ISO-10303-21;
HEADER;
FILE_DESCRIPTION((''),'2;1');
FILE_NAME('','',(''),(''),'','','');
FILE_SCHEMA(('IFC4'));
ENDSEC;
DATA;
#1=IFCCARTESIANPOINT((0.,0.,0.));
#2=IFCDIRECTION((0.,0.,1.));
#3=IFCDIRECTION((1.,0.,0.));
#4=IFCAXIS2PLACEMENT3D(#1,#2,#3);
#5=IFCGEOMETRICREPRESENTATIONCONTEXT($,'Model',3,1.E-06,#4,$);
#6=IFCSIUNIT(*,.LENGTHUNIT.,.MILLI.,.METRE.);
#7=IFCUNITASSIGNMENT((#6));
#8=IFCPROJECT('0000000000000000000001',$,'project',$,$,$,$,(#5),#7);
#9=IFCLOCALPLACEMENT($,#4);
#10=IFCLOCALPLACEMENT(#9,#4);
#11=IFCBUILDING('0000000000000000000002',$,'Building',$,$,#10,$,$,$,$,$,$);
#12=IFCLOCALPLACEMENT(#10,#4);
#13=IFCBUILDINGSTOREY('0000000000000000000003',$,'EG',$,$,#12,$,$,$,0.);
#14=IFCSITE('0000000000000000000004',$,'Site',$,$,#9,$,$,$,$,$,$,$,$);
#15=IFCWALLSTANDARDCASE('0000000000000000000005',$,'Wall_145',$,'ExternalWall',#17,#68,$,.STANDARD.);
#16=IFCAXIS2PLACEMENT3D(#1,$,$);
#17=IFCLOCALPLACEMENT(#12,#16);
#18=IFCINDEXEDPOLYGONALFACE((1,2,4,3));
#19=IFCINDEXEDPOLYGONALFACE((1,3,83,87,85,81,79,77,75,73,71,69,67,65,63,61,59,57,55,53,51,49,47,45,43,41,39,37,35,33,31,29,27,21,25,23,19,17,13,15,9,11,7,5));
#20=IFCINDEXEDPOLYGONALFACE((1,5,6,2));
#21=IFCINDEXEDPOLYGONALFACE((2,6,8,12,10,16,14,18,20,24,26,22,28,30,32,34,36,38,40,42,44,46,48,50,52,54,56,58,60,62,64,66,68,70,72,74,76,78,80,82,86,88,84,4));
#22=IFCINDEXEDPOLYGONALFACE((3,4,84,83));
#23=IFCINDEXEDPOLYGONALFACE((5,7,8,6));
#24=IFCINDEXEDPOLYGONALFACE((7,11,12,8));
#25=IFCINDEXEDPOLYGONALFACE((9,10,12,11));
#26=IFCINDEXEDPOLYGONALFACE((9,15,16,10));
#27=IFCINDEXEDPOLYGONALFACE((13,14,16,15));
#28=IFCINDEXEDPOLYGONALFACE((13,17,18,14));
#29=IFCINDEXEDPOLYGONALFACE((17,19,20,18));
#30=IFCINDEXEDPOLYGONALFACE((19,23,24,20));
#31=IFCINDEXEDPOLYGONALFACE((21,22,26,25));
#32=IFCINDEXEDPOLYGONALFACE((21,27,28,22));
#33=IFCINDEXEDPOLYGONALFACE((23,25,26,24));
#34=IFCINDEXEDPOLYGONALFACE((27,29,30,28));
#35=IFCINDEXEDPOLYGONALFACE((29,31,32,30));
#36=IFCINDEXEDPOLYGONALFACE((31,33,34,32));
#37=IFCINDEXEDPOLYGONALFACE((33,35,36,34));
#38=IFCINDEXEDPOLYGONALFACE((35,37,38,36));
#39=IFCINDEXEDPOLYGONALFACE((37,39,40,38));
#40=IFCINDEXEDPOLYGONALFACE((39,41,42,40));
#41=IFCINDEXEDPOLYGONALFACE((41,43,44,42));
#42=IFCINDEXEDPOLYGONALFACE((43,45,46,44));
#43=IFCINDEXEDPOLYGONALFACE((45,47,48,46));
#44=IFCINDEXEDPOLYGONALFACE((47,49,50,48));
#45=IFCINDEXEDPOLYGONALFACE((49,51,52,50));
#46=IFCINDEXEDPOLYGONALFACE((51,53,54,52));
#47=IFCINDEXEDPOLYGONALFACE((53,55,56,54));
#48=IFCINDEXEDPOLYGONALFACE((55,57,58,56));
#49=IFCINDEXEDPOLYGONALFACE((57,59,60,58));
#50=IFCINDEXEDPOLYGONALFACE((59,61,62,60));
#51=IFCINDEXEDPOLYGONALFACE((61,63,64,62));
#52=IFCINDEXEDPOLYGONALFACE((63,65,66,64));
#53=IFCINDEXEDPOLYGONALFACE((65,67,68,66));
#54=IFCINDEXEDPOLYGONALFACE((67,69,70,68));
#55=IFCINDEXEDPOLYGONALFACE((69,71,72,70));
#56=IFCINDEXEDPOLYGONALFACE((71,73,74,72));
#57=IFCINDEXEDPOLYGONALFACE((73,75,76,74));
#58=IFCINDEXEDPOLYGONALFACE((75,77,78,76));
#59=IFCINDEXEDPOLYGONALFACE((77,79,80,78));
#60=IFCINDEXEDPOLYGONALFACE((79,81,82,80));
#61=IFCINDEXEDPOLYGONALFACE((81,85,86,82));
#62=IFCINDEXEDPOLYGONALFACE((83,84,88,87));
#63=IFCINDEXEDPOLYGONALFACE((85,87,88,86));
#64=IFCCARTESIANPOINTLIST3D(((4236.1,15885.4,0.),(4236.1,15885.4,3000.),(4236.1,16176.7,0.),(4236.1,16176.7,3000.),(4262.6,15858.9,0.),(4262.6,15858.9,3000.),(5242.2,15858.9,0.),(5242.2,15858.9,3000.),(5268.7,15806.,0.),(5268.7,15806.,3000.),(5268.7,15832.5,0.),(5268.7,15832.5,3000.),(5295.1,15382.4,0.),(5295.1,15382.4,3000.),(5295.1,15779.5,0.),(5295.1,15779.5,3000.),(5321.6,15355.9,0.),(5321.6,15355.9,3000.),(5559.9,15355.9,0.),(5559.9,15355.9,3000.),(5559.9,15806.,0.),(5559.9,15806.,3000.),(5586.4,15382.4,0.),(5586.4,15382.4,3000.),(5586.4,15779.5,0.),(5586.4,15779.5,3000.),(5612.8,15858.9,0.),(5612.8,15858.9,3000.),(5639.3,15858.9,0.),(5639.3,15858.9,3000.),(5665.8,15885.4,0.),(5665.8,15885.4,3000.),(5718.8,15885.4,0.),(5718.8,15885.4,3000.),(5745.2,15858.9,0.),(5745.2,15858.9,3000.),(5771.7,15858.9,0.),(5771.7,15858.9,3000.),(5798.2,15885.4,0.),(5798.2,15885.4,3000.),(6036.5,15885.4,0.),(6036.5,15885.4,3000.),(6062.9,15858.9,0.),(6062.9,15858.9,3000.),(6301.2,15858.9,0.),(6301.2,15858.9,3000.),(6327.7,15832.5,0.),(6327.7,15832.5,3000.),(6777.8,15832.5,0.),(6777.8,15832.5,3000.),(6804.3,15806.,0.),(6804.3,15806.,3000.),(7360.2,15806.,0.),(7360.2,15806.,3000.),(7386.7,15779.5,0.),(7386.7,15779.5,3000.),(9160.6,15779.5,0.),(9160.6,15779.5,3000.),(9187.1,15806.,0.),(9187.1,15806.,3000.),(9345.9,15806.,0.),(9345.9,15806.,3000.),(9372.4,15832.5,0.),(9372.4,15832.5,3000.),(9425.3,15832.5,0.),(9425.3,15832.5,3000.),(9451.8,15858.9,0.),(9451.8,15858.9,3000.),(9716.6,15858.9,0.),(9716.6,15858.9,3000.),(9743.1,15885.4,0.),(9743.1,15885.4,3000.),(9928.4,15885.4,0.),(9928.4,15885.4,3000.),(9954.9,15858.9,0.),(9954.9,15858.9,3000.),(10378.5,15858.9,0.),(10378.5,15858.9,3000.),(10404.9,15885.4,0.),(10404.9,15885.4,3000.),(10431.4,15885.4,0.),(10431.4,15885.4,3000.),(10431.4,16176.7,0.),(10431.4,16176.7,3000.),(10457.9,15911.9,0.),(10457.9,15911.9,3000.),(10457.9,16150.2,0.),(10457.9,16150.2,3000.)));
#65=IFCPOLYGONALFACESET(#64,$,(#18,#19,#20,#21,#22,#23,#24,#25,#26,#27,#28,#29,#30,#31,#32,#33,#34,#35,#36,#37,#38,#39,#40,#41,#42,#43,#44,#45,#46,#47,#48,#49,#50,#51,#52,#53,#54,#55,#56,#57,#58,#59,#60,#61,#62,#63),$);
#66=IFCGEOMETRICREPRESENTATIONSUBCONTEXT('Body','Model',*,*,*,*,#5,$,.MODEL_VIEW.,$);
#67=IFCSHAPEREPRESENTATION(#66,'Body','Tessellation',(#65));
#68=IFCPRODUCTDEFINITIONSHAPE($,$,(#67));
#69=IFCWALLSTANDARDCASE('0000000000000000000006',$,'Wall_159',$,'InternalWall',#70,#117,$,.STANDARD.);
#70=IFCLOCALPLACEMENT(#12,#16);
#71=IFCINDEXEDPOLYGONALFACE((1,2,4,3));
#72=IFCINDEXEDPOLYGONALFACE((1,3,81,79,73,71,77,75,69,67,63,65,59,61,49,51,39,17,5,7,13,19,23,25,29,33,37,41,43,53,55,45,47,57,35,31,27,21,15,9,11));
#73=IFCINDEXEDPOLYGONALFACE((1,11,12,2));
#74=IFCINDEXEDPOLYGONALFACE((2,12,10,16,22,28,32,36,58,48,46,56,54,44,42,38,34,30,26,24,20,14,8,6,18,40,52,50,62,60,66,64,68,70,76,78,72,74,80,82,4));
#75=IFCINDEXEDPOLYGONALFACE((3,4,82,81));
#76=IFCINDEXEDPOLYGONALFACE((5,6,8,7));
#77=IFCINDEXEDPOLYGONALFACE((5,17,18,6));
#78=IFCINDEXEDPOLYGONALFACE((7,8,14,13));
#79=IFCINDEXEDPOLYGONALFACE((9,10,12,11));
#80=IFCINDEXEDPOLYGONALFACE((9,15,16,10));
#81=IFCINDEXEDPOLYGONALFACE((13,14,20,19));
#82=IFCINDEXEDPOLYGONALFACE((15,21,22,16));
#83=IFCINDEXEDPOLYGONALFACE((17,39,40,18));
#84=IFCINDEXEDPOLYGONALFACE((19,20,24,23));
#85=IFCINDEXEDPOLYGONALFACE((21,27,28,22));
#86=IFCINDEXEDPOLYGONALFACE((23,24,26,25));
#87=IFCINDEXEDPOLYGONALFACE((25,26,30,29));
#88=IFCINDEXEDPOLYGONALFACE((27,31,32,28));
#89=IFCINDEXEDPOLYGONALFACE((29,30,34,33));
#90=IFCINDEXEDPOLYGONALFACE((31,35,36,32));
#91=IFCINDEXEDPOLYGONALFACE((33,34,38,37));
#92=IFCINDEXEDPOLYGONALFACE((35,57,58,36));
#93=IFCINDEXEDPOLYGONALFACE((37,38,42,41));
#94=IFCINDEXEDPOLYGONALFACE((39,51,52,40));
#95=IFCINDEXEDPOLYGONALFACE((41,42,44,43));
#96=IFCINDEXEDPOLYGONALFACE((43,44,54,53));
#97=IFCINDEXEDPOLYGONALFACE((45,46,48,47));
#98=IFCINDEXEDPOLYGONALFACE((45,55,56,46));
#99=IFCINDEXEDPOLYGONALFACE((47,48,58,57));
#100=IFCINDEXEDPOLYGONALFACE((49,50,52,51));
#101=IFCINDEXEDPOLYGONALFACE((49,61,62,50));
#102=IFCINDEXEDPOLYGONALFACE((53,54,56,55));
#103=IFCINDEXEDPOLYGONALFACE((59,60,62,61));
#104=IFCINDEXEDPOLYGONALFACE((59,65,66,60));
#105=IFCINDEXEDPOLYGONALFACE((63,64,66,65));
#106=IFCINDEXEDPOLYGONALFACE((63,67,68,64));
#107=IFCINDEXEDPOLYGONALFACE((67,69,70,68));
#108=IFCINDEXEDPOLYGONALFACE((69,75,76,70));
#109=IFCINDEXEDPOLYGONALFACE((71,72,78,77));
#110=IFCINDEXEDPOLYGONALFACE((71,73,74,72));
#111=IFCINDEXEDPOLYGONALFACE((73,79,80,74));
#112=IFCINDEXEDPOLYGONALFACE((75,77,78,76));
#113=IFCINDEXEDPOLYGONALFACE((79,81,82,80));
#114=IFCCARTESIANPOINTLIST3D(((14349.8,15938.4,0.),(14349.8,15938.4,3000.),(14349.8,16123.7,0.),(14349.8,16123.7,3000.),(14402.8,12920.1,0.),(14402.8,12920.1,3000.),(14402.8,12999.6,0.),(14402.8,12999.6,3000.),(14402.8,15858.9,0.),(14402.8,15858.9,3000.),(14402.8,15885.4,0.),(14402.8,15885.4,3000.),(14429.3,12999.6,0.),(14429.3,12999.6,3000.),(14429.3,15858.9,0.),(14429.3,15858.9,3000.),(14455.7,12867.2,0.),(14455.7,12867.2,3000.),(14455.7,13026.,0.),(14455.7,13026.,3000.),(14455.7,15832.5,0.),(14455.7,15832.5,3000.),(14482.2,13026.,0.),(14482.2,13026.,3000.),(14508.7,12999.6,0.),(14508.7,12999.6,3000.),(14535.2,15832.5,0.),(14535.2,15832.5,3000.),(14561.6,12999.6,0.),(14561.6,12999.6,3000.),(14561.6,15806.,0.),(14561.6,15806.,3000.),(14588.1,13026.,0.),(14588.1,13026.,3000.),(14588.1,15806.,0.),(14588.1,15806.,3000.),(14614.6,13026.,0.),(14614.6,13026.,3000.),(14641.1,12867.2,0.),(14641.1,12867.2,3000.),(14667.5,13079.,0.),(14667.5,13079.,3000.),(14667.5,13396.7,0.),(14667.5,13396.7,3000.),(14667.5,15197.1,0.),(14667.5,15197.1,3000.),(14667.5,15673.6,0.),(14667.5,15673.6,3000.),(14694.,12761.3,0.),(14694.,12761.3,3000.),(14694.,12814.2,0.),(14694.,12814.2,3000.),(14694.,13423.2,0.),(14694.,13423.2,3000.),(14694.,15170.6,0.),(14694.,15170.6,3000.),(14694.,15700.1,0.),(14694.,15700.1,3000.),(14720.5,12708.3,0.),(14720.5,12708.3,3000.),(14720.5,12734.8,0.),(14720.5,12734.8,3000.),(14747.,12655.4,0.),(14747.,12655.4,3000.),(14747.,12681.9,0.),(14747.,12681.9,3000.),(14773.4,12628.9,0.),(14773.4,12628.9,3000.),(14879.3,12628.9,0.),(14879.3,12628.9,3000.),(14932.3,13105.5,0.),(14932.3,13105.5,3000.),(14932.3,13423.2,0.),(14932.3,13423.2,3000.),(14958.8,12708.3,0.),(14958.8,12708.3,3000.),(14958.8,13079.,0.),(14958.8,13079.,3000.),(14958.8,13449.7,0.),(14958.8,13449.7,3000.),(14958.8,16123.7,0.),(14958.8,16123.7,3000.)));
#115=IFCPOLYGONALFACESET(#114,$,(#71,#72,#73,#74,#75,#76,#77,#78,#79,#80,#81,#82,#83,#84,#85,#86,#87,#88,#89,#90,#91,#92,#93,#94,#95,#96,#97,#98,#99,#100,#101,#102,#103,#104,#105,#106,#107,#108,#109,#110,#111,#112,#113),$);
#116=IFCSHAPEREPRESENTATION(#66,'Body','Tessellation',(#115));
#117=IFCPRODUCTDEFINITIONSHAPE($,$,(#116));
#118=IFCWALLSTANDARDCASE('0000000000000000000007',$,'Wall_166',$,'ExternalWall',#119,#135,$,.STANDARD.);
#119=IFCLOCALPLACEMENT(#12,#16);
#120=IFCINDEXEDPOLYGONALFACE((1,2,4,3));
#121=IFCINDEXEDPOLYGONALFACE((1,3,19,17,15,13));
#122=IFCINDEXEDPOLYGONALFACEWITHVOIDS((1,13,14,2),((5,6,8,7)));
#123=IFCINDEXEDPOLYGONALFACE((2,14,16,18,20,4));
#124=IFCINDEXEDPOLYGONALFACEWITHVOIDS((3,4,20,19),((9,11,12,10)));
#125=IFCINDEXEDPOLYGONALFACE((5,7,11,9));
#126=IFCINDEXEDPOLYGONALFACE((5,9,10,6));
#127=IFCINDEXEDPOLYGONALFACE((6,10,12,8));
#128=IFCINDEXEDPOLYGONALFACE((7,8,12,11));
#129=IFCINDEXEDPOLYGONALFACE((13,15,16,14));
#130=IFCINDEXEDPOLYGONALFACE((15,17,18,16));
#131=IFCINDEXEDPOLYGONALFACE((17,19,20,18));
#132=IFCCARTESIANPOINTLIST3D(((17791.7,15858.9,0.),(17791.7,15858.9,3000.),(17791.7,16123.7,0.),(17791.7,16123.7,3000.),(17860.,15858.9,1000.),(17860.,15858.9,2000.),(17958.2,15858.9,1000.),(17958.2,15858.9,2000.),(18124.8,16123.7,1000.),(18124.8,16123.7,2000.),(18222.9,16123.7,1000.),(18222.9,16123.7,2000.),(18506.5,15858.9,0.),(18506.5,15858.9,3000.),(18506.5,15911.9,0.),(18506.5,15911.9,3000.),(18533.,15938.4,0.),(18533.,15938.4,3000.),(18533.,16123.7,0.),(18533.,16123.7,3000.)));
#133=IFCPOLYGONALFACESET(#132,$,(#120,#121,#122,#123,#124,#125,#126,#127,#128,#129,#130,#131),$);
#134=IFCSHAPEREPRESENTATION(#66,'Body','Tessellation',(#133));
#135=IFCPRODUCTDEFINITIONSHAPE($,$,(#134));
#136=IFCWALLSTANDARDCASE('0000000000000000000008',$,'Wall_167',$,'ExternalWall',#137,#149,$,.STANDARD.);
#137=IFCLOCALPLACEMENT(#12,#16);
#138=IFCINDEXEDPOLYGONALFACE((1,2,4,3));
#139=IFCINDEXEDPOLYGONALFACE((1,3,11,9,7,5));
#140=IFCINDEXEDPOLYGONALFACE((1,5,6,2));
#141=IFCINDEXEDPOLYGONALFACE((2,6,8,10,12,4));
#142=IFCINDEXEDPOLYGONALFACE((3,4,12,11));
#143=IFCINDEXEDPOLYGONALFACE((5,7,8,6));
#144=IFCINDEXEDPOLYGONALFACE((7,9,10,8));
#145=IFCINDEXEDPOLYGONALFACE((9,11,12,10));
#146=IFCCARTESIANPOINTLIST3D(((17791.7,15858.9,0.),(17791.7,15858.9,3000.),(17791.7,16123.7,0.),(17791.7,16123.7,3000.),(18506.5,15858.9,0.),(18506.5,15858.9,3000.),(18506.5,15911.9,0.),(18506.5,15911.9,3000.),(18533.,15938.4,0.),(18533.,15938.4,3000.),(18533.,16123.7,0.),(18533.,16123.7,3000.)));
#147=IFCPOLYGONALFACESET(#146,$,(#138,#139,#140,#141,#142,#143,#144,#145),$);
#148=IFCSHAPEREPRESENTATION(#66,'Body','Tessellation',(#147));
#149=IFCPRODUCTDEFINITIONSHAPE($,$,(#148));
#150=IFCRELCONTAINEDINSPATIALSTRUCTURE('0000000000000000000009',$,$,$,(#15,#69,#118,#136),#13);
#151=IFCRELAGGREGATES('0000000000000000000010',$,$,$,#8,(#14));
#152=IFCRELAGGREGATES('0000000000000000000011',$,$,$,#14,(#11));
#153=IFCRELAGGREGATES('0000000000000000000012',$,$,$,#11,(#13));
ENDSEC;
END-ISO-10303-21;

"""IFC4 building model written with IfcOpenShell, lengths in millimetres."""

from ifc_helpers import new_model, si_unit, frame, origin_with_axes, place, context, subcontext, project, spatial, polyline, rectangle, outline, extrude, element, save


model = new_model("IFC4")

# Units and contexts
model_context = context("Model", 3, precision=1e-06, world=origin_with_axes())
body_context = subcontext(model_context, "Body", "Model", "MODEL_VIEW")
ifc_project = project(units=[si_unit("LENGTHUNIT", "METRE", prefix="MILLI")], contexts=[model_context])

# Site, building, storey
site_placement = place(None, origin_with_axes())
site = spatial("IfcSite", under=ifc_project, at=site_placement, Name="Site")
building_placement = place(site_placement, origin_with_axes())
building = spatial("IfcBuilding", under=site, at=building_placement, Name="Building")
storey_placement = place(building_placement, origin_with_axes())
storey = spatial("IfcBuildingStorey", under=building, at=storey_placement, Name="EG", Elevation=0.0)

# Walls
wall_1_placement = place(storey_placement, origin_with_axes())
element("IfcWallStandardCase", 1, at=wall_1_placement, inside=storey, Name="Wall_145", ObjectType="ExternalWall", PredefinedType="STANDARD", context=body_context, shape_type="SweptSolid", body=[
    extrude(outline(polyline([(5321.6, 15355.9, 0.0), (5295.1, 15382.4, 0.0), (5295.1, 15779.5, 0.0), (5268.7, 15806.0, 0.0), (5268.7, 15832.5, 0.0), (5242.2, 15858.9, 0.0), (4262.6, 15858.9, 0.0), (4236.1, 15885.4, 0.0), (4236.1, 16176.7, 0.0), (10431.4, 16176.7, 0.0), (10457.9, 16150.2, 0.0), (10457.9, 15911.9, 0.0), (10431.4, 15885.4, 0.0), (10404.9, 15885.4, 0.0), (10378.5, 15858.9, 0.0), (9954.9, 15858.9, 0.0), (9928.4, 15885.4, 0.0), (9743.1, 15885.4, 0.0), (9716.6, 15858.9, 0.0), (9451.8, 15858.9, 0.0), (9425.3, 15832.5, 0.0), (9372.4, 15832.5, 0.0), (9345.9, 15806.0, 0.0), (9187.1, 15806.0, 0.0), (9160.6, 15779.5, 0.0), (7386.7, 15779.5, 0.0), (7360.2, 15806.0, 0.0), (6804.3, 15806.0, 0.0), (6777.8, 15832.5, 0.0), (6327.7, 15832.5, 0.0), (6301.2, 15858.9, 0.0), (6062.9, 15858.9, 0.0), (6036.5, 15885.4, 0.0), (5798.2, 15885.4, 0.0), (5771.7, 15858.9, 0.0), (5745.2, 15858.9, 0.0), (5718.8, 15885.4, 0.0), (5665.8, 15885.4, 0.0), (5639.3, 15858.9, 0.0), (5612.8, 15858.9, 0.0), (5559.9, 15806.0, 0.0), (5586.4, 15779.5, 0.0), (5586.4, 15382.4, 0.0), (5559.9, 15355.9, 0.0), (5321.6, 15355.9, 0.0)])), origin_with_axes(), (0.0, 0.0, 1.0), 3000.0),
])
wall_2_placement = place(storey_placement, origin_with_axes())
element("IfcWallStandardCase", 2, at=wall_2_placement, inside=storey, Name="Wall_159", ObjectType="InternalWall", PredefinedType="STANDARD", context=body_context, shape_type="SweptSolid", body=[
    extrude(outline(polyline([(14773.4, 12628.9, 0.0), (14747.0, 12655.4, 0.0), (14747.0, 12681.9, 0.0), (14720.5, 12708.3, 0.0), (14720.5, 12734.8, 0.0), (14694.0, 12761.3, 0.0), (14694.0, 12814.2, 0.0), (14641.1, 12867.2, 0.0), (14455.7, 12867.2, 0.0), (14402.8, 12920.1, 0.0), (14402.8, 12999.6, 0.0), (14429.3, 12999.6, 0.0), (14455.7, 13026.0, 0.0), (14482.2, 13026.0, 0.0), (14508.7, 12999.6, 0.0), (14561.6, 12999.6, 0.0), (14588.1, 13026.0, 0.0), (14614.6, 13026.0, 0.0), (14667.5, 13079.0, 0.0), (14667.5, 13396.7, 0.0), (14694.0, 13423.2, 0.0), (14694.0, 15170.6, 0.0), (14667.5, 15197.1, 0.0), (14667.5, 15673.6, 0.0), (14694.0, 15700.1, 0.0), (14588.1, 15806.0, 0.0), (14561.6, 15806.0, 0.0), (14535.2, 15832.5, 0.0), (14455.7, 15832.5, 0.0), (14429.3, 15858.9, 0.0), (14402.8, 15858.9, 0.0), (14402.8, 15885.4, 0.0), (14349.8, 15938.4, 0.0), (14349.8, 16123.7, 0.0), (14958.8, 16123.7, 0.0), (14958.8, 13449.7, 0.0), (14932.3, 13423.2, 0.0), (14932.3, 13105.5, 0.0), (14958.8, 13079.0, 0.0), (14958.8, 12708.3, 0.0), (14879.3, 12628.9, 0.0), (14773.4, 12628.9, 0.0)])), origin_with_axes(), (0.0, 0.0, 1.0), 3000.0),
])

# Wall, opening
wall_3_placement = place(storey_placement, origin_with_axes())
wall_3 = element("IfcWallStandardCase", 3, at=wall_3_placement, inside=storey, Name="Wall_166", ObjectType="ExternalWall", PredefinedType="STANDARD", context=body_context, shape_type="SweptSolid", body=[
    extrude(outline(polyline([(17791.7, 15858.9, 0.0), (17791.7, 16123.7, 0.0), (18533.0, 16123.7, 0.0), (18533.0, 15938.4, 0.0), (18506.5, 15911.9, 0.0), (18506.5, 15858.9, 0.0), (17791.7, 15858.9, 0.0)])), origin_with_axes(), (0.0, 0.0, 1.0), 3000.0),
])
opening_placement = place(wall_3_placement, origin_with_axes())
element("IfcOpeningElement", 4, at=opening_placement, inside=storey, cuts=wall_3, context=body_context, shape_type="SweptSolid", body=[
    extrude(rectangle(XDim=823.7, YDim=69.4), frame((17911.5, 15861.3, 1000.0), z_axis=(0.0, 0.0, 1.0), x_axis=(-0.707107, -0.707107, 0.0)), (0.0, 0.0, 1.0), 1000.0),
])

# Wall
for number, where, z_axis, x_axis, name in (
    (5, (0.0, 0.0, 0.0), (0.0, 0.0, 1.0), (1.0, 0.0, 0.0), "Wall_167"),
):
    element("IfcWallStandardCase", number, at=place(storey_placement, frame(where, z_axis=z_axis, x_axis=x_axis)), inside=storey, Name=name, ObjectType="ExternalWall", PredefinedType="STANDARD", context=body_context, shape_type="SweptSolid", body=[
        extrude(outline(polyline([(17791.7, 15858.9, 0.0), (17791.7, 16123.7, 0.0), (18533.0, 16123.7, 0.0), (18533.0, 15938.4, 0.0), (18506.5, 15911.9, 0.0), (18506.5, 15858.9, 0.0), (17791.7, 15858.9, 0.0)])), origin_with_axes(), (0.0, 0.0, 1.0), 3000.0),
    ])

save(model, "model.ifc")
